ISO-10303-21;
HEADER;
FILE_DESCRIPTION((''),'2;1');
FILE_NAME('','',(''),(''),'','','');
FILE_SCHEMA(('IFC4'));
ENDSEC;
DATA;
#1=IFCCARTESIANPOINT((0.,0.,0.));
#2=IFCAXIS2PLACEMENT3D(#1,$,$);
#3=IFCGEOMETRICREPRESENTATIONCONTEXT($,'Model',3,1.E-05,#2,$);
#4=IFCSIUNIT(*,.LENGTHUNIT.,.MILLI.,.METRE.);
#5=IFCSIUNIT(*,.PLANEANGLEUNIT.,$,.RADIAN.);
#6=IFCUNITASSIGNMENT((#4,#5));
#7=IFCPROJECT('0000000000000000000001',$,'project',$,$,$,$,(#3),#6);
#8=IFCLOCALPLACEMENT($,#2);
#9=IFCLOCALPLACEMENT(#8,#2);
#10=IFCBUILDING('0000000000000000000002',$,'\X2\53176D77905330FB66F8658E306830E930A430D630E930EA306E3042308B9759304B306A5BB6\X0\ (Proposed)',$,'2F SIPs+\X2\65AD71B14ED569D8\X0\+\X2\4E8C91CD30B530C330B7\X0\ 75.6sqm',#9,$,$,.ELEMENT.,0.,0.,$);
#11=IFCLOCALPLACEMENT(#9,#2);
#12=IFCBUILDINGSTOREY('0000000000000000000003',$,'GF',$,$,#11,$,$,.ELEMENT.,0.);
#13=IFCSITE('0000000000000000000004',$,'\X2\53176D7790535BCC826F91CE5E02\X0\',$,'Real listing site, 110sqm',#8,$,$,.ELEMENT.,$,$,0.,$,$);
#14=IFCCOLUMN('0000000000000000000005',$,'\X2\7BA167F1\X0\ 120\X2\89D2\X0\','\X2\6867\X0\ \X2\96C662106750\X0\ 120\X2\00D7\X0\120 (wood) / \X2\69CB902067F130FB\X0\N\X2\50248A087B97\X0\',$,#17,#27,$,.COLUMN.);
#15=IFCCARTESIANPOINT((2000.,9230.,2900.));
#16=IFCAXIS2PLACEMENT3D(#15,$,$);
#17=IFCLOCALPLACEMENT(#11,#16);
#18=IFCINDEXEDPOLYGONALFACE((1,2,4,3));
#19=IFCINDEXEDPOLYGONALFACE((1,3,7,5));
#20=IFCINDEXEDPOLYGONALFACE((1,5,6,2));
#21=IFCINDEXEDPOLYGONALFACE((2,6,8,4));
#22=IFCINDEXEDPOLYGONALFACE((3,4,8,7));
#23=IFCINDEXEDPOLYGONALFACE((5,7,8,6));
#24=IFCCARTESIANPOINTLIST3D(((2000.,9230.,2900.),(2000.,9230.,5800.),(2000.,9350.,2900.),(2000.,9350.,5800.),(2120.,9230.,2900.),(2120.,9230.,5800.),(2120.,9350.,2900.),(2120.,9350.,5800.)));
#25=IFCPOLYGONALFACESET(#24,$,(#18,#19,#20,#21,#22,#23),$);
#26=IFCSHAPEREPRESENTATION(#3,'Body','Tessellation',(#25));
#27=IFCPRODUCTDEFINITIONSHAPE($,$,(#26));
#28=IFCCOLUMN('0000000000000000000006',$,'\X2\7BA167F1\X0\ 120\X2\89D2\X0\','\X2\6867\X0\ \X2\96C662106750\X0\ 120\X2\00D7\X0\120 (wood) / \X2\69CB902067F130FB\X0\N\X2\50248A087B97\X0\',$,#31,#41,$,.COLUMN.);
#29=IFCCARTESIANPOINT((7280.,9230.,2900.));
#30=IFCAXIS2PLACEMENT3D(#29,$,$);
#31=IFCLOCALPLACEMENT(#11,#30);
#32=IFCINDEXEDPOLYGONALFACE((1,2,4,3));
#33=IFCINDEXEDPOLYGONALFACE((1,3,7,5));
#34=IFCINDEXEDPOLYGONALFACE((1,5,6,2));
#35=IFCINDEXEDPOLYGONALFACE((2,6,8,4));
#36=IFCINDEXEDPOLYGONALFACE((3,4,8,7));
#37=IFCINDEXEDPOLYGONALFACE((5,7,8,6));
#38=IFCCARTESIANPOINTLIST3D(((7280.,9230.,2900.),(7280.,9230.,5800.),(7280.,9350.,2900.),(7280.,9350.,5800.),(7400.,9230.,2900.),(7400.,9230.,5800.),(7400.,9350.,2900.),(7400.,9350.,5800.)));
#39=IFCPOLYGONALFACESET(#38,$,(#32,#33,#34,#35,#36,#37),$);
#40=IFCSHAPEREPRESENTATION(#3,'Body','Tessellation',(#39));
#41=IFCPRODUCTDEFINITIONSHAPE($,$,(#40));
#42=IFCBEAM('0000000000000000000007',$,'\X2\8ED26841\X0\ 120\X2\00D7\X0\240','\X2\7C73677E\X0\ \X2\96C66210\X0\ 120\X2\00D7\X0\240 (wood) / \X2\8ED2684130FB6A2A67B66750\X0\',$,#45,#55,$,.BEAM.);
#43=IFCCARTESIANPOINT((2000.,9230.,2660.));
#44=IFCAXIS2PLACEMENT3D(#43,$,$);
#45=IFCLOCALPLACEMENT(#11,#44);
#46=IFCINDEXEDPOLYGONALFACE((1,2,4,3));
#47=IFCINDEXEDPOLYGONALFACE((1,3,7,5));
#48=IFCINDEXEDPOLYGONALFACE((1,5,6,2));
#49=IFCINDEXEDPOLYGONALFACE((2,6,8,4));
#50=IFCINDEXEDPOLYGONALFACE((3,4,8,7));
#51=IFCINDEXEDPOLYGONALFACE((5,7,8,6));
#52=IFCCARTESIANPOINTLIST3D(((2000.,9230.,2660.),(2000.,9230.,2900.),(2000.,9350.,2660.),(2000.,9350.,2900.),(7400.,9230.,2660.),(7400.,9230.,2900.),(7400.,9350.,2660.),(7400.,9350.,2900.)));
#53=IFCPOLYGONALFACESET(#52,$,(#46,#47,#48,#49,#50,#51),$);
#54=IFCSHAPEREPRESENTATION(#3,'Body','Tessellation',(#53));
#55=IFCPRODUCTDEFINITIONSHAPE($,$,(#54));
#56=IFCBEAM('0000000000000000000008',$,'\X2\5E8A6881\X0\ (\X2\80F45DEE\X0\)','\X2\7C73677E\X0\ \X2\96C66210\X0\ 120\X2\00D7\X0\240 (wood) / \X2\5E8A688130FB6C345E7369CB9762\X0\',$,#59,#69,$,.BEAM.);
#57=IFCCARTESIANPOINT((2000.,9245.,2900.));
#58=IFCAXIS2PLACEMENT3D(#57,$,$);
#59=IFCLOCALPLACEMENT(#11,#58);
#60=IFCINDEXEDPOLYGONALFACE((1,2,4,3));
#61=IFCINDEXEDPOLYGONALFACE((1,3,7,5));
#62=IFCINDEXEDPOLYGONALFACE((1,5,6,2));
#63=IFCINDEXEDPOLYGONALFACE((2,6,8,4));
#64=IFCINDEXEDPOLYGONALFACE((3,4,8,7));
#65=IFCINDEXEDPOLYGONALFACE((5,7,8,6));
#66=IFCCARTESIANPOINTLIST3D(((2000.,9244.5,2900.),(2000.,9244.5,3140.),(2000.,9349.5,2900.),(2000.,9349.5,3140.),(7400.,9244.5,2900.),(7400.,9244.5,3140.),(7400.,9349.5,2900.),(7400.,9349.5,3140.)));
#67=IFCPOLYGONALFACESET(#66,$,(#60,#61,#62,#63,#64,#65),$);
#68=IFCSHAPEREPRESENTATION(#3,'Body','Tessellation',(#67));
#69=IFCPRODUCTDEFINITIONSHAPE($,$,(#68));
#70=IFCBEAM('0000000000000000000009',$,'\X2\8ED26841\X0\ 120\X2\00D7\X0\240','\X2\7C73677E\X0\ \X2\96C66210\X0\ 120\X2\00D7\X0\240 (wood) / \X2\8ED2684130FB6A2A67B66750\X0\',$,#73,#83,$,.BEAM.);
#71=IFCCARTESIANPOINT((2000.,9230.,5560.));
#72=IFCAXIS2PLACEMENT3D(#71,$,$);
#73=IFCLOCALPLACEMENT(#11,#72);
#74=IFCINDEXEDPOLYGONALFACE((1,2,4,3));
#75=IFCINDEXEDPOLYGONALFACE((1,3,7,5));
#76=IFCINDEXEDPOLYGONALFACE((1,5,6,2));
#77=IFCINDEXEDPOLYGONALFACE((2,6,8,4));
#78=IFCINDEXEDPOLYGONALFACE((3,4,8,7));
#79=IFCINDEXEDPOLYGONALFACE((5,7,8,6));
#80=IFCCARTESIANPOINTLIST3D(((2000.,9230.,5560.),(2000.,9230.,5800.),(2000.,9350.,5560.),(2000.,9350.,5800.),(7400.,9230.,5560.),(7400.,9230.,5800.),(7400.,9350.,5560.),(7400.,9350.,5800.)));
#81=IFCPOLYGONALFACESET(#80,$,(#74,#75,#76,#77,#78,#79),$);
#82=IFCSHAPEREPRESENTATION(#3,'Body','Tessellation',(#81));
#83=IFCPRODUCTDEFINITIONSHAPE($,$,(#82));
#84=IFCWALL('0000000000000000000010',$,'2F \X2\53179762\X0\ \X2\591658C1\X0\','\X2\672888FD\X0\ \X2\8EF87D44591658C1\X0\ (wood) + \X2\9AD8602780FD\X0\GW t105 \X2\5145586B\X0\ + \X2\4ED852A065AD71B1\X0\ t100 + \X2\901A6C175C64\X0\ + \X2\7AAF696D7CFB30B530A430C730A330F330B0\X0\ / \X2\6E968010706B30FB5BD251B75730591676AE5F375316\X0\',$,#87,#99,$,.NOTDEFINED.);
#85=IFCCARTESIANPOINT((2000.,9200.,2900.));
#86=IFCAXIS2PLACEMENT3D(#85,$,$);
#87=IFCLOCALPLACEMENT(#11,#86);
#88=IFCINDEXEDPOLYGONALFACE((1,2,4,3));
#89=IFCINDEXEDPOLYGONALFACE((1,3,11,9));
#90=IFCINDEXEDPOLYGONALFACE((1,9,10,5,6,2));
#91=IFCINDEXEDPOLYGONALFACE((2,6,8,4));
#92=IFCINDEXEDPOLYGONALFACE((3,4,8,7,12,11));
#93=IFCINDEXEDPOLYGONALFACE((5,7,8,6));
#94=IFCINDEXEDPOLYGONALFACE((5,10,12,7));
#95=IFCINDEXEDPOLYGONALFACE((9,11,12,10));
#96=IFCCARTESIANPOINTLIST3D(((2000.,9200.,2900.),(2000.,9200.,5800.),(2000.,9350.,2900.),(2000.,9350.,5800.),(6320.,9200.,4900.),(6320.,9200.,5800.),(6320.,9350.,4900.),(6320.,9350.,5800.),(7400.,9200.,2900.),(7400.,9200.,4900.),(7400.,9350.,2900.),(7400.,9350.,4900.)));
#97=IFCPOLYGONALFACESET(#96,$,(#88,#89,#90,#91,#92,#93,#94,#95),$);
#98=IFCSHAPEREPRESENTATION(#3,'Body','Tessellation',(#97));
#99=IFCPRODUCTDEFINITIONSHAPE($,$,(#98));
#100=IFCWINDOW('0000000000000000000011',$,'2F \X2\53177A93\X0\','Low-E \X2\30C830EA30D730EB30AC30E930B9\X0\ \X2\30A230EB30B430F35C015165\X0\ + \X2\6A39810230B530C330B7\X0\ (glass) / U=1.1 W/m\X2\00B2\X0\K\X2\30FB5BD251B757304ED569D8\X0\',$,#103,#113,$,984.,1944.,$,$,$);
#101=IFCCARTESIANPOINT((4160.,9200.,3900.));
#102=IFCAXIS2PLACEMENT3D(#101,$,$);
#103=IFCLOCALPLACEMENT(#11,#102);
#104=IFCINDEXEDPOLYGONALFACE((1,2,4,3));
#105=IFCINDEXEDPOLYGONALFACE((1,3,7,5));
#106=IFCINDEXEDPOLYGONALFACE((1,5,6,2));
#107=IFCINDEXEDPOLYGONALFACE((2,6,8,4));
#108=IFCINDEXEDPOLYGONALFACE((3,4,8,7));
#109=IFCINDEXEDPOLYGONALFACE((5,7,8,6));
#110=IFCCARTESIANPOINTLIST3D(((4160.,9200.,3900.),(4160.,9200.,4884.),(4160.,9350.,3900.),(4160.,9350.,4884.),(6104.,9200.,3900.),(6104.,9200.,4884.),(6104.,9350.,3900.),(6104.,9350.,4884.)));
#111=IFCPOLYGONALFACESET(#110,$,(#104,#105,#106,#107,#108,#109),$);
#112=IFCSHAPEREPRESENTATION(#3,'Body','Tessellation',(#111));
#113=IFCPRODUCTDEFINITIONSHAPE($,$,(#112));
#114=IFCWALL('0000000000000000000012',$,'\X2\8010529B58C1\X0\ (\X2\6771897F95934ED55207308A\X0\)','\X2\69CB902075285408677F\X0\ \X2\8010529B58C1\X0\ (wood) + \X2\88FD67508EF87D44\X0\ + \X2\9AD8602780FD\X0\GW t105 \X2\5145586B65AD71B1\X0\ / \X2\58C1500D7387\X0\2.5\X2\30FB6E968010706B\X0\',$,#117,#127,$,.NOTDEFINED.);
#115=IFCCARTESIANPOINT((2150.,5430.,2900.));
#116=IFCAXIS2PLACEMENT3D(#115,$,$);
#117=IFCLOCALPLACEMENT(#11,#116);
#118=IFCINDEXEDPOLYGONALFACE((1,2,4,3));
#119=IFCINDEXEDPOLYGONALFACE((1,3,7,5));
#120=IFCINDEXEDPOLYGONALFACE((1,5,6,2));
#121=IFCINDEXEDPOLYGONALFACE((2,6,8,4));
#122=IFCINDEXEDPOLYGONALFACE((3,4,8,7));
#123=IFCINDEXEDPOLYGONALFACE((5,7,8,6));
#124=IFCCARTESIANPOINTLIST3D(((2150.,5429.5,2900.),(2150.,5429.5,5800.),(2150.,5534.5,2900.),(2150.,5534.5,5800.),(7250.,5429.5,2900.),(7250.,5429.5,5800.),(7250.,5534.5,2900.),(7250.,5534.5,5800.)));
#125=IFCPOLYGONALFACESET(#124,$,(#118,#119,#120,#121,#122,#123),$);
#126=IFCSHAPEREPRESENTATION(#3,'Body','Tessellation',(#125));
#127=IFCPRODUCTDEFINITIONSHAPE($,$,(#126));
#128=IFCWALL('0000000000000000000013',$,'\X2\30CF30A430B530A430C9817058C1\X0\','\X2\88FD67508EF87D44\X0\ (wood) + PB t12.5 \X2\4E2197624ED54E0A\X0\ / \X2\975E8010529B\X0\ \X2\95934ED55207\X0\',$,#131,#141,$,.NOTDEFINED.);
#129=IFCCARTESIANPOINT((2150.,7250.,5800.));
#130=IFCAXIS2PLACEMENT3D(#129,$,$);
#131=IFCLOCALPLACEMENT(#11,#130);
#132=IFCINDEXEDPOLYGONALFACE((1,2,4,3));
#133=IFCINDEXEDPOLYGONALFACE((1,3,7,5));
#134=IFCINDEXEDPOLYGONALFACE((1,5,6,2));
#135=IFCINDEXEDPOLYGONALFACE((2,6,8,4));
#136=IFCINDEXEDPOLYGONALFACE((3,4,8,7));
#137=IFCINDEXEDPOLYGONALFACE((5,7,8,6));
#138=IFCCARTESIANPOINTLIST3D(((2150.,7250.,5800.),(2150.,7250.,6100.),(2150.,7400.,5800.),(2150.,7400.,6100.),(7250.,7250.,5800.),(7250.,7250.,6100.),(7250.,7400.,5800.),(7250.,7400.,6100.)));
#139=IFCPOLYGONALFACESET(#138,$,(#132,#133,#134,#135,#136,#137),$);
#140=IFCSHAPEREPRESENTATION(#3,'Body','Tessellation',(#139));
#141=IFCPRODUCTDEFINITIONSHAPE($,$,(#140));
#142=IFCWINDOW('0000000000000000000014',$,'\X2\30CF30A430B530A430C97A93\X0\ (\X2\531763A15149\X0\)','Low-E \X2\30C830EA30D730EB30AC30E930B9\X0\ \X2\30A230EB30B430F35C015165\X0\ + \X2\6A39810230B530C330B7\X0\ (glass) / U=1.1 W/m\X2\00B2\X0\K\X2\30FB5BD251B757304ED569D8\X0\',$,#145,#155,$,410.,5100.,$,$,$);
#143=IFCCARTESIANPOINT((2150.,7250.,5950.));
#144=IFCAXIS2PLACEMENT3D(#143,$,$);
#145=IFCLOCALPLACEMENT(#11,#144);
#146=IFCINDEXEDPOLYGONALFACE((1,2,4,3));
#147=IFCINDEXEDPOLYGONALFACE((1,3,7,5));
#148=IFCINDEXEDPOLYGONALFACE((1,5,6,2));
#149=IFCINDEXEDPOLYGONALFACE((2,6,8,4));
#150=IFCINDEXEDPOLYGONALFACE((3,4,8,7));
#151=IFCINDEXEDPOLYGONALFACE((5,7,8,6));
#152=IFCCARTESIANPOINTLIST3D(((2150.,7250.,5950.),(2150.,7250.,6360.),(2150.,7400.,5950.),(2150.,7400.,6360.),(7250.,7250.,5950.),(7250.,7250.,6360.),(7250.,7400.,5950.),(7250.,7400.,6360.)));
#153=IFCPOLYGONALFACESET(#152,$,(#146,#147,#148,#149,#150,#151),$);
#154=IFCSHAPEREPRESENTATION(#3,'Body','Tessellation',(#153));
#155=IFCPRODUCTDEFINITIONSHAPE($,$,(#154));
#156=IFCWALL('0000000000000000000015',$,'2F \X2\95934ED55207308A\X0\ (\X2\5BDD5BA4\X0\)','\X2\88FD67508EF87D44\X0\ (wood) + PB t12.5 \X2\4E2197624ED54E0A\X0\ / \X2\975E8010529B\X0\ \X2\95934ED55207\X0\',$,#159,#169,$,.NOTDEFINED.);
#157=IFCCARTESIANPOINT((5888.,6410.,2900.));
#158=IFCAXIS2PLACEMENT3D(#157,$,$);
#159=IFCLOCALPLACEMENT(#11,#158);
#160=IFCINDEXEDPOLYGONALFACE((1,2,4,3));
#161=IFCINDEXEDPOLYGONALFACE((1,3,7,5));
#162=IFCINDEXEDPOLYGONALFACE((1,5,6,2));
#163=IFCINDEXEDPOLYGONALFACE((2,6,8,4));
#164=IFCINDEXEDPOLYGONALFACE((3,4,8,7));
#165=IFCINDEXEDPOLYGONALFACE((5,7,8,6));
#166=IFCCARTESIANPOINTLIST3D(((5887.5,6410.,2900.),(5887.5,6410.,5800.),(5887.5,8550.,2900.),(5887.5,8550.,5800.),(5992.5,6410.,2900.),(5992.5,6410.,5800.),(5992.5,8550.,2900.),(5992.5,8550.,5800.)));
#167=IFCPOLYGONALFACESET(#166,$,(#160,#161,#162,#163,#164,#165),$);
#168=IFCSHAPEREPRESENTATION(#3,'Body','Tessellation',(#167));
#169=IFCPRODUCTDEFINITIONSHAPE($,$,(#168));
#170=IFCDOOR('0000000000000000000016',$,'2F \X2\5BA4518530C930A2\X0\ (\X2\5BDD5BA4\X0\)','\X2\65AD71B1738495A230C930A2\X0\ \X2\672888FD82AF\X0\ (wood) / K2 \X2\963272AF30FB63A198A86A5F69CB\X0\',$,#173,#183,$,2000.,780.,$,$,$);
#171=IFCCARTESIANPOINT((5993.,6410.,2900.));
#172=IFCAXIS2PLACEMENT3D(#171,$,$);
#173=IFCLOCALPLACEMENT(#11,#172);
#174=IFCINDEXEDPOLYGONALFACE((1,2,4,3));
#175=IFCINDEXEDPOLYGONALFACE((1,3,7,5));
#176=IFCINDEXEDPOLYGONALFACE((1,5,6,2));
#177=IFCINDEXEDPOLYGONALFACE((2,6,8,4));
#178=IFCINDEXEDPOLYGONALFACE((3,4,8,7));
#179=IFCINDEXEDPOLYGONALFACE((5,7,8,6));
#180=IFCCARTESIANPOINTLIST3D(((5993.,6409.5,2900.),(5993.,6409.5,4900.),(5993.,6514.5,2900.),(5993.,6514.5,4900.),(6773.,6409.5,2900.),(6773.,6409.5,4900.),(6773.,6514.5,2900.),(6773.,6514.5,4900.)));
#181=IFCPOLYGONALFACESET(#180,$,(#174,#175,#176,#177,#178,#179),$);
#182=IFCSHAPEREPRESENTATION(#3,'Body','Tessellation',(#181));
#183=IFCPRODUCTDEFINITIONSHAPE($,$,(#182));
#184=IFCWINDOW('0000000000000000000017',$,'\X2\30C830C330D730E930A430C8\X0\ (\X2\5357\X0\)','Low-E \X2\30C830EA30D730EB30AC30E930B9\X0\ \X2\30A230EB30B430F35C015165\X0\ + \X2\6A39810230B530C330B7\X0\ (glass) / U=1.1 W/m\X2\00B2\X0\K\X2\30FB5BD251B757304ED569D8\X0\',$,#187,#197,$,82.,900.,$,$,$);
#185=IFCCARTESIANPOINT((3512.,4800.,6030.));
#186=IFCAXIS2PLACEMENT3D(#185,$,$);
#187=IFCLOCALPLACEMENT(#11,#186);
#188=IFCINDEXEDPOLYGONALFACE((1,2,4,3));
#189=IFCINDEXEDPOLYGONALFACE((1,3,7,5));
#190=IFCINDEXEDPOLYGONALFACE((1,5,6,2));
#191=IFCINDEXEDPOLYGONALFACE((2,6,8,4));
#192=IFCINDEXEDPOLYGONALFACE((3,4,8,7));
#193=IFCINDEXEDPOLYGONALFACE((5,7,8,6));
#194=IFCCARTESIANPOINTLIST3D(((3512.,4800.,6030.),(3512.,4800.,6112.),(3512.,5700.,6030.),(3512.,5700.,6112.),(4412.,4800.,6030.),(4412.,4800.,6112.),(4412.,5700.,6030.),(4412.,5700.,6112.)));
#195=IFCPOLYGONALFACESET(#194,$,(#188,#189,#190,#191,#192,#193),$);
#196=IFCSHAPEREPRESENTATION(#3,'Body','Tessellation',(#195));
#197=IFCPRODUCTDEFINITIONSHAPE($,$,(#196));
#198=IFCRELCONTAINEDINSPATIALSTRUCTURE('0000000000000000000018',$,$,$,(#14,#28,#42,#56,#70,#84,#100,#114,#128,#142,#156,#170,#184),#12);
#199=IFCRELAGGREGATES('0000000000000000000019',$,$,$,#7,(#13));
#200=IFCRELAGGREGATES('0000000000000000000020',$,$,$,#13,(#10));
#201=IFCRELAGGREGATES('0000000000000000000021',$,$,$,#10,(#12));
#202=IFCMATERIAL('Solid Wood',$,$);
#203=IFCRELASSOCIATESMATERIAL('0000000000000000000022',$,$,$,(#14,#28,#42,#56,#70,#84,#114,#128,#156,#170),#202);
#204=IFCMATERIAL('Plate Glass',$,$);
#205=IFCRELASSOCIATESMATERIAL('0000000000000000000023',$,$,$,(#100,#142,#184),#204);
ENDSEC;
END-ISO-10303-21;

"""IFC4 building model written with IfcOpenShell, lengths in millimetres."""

from ifc_helpers import new_model, si_unit, frame, frame_2d, origin, place, context, project, spatial, rectangle, extrude, material, element, fill, save


model = new_model("IFC4")

# Units and contexts
model_context = context("Model", 3, precision=1e-05, world=origin())
ifc_project = project(units=[si_unit("LENGTHUNIT", "METRE", prefix="MILLI"), si_unit("PLANEANGLEUNIT", "RADIAN")], contexts=[model_context])

# Site, building, storey
site_placement = place(None, origin())
site = spatial("IfcSite", under=ifc_project, at=site_placement, Name="北海道富良野市", ObjectType="Real listing site, 110sqm", CompositionType="ELEMENT", RefElevation=0.0)
building_placement = place(site_placement, origin())
building = spatial("IfcBuilding", under=site, at=building_placement, Name="北海道・書斎とライブラリのある静かな家 (Proposed)", ObjectType="2F SIPs+断熱仕様+二重サッシ 75.6sqm", CompositionType="ELEMENT", ElevationOfRefHeight=0.0, ElevationOfTerrain=0.0)
storey_placement = place(building_placement, origin())
storey = spatial("IfcBuildingStorey", under=building, at=storey_placement, Name="GF", CompositionType="ELEMENT", Elevation=0.0)

# Columns
ifc_material_1 = material(Name="Solid Wood")
column_1_placement = place(storey_placement, frame((2000.0, 9230.0, 2900.0)))
element("IfcColumn", 1, at=column_1_placement, inside=storey, material=ifc_material_1, Name="管柱 120角", Description="桧 集成材 120×120 (wood) / 構造柱・N値計算", PredefinedType="COLUMN", context=model_context, shape_type="SweptSolid", body=[
    extrude(rectangle(XDim=120.0, YDim=120.0, at=frame_2d((60.0, 60.0))), frame((2000.0, 9230.0, 2900.0)), (0.0, 0.0, 1.0), 2900.0),
])
column_2_placement = place(storey_placement, frame((7280.0, 9230.0, 2900.0)))
element("IfcColumn", 2, at=column_2_placement, inside=storey, material=ifc_material_1, Name="管柱 120角", Description="桧 集成材 120×120 (wood) / 構造柱・N値計算", PredefinedType="COLUMN", context=model_context, shape_type="SweptSolid", body=[
    extrude(rectangle(XDim=120.0, YDim=120.0, at=frame_2d((60.0, 60.0))), frame((7280.0, 9230.0, 2900.0)), (0.0, 0.0, 1.0), 2900.0),
])

# Beams
beam_1_placement = place(storey_placement, frame((2000.0, 9230.0, 2660.0)))
element("IfcBeam", 3, at=beam_1_placement, inside=storey, material=ifc_material_1, Name="軒桁 120×240", Description="米松 集成 120×240 (wood) / 軒桁・横架材", PredefinedType="BEAM", context=model_context, shape_type="SweptSolid", body=[
    extrude(rectangle(XDim=5400.0, YDim=120.0, at=frame_2d((2700.0, 60.0))), frame((2000.0, 9230.0, 2660.0)), (0.0, 0.0, 1.0), 240.0),
])
beam_2_placement = place(storey_placement, frame((2000.0, 9245.0, 2900.0)))
element("IfcBeam", 4, at=beam_2_placement, inside=storey, material=ifc_material_1, Name="床梁 (胴差)", Description="米松 集成 120×240 (wood) / 床梁・水平構面", PredefinedType="BEAM", context=model_context, shape_type="SweptSolid", body=[
    extrude(rectangle(XDim=5400.0, YDim=105.0, at=frame_2d((2700.0, 52.0))), frame((2000.0, 9245.0, 2900.0)), (0.0, 0.0, 1.0), 240.0),
])
beam_3_placement = place(storey_placement, frame((2000.0, 9230.0, 5560.0)))
element("IfcBeam", 5, at=beam_3_placement, inside=storey, material=ifc_material_1, Name="軒桁 120×240", Description="米松 集成 120×240 (wood) / 軒桁・横架材", PredefinedType="BEAM", context=model_context, shape_type="SweptSolid", body=[
    extrude(rectangle(XDim=5400.0, YDim=120.0, at=frame_2d((2700.0, 60.0))), frame((2000.0, 9230.0, 5560.0)), (0.0, 0.0, 1.0), 240.0),
])

# Wall, opening, window
wall_1_placement = place(storey_placement, frame((2000.0, 9200.0, 2900.0)))
wall_1 = element("IfcWall", 6, at=wall_1_placement, inside=storey, material=ifc_material_1, Name="2F 北面 外壁", Description="木製 軸組外壁 (wood) + 高性能GW t105 充填 + 付加断熱 t100 + 通気層 + 窯業系サイディング / 準耐火・寒冷地外皮強化", PredefinedType="NOTDEFINED", context=model_context, shape_type="SweptSolid", body=[
    extrude(rectangle(XDim=5400.0, YDim=150.0, at=frame_2d((2700.0, 75.0))), frame((2000.0, 9200.0, 2900.0)), (0.0, 0.0, 1.0), 2900.0),
])
opening_1_placement = place(storey_placement, frame((4160.0, 9200.0, 3900.0)))
opening_1 = element("IfcOpeningElement", 7, at=opening_1_placement, cuts=wall_1, PredefinedType="NOTDEFINED", context=model_context, shape_type="SweptSolid", body=[
    extrude(rectangle(XDim=1944.0, YDim=150.0, at=frame_2d((972.0, 75.0))), frame((4160.0, 9200.0, 3900.0)), (0.0, 0.0, 1.0), 984.0),
])
ifc_material_2 = material(Name="Plate Glass")
window_1_placement = place(storey_placement, frame((4160.0, 9200.0, 3900.0)))
window_1 = element("IfcWindow", 8, at=window_1_placement, inside=storey, material=ifc_material_2, Name="2F 北窓", Description="Low-E トリプルガラス アルゴン封入 + 樹脂サッシ (glass) / U=1.1 W/m²K・寒冷地仕様", OverallHeight=984.0, OverallWidth=1944.0, context=model_context, shape_type="SweptSolid", body=[
    extrude(rectangle(XDim=1944.0, YDim=150.0, at=frame_2d((972.0, 75.0))), frame((4160.0, 9200.0, 3900.0)), (0.0, 0.0, 1.0), 984.0),
])
fill(opening_1, window_1)

# Wall
wall_2_placement = place(storey_placement, frame((2150.0, 5430.0, 2900.0)))
element("IfcWall", 9, at=wall_2_placement, inside=storey, material=ifc_material_1, Name="耐力壁 (東西間仕切り)", Description="構造用合板 耐力壁 (wood) + 製材軸組 + 高性能GW t105 充填断熱 / 壁倍率2.5・準耐火", PredefinedType="NOTDEFINED", context=model_context, shape_type="SweptSolid", body=[
    extrude(rectangle(XDim=5100.0, YDim=105.0, at=frame_2d((2550.0, 52.0))), frame((2150.0, 5430.0, 2900.0)), (0.0, 0.0, 1.0), 2900.0),
])

# Wall, opening, window
wall_3_placement = place(storey_placement, frame((2150.0, 7250.0, 5800.0)))
wall_3 = element("IfcWall", 10, at=wall_3_placement, inside=storey, material=ifc_material_1, Name="ハイサイド腰壁", Description="製材軸組 (wood) + PB t12.5 両面仕上 / 非耐力 間仕切", PredefinedType="NOTDEFINED", context=model_context, shape_type="SweptSolid", body=[
    extrude(rectangle(XDim=5100.0, YDim=150.0, at=frame_2d((2550.0, 75.0))), frame((2150.0, 7250.0, 5800.0)), (0.0, 0.0, 1.0), 700.0),
])
opening_2_placement = place(storey_placement, frame((2150.0, 7250.0, 5950.0)))
opening_2 = element("IfcOpeningElement", 11, at=opening_2_placement, cuts=wall_3, PredefinedType="NOTDEFINED", context=model_context, shape_type="SweptSolid", body=[
    extrude(rectangle(XDim=5100.0, YDim=150.0, at=frame_2d((2550.0, 75.0))), frame((2150.0, 7250.0, 5950.0)), (0.0, 0.0, 1.0), 410.0),
])
window_2_placement = place(storey_placement, frame((2150.0, 7250.0, 5950.0)))
window_2 = element("IfcWindow", 12, at=window_2_placement, inside=storey, material=ifc_material_2, Name="ハイサイド窓 (北採光)", Description="Low-E トリプルガラス アルゴン封入 + 樹脂サッシ (glass) / U=1.1 W/m²K・寒冷地仕様", OverallHeight=410.0, OverallWidth=5100.0, context=model_context, shape_type="SweptSolid", body=[
    extrude(rectangle(XDim=5100.0, YDim=150.0, at=frame_2d((2550.0, 75.0))), frame((2150.0, 7250.0, 5950.0)), (0.0, 0.0, 1.0), 410.0),
])
fill(opening_2, window_2)

# Wall
wall_4_placement = place(storey_placement, frame((5888.0, 6410.0, 2900.0)))
element("IfcWall", 13, at=wall_4_placement, inside=storey, material=ifc_material_1, Name="2F 間仕切り (寝室)", Description="製材軸組 (wood) + PB t12.5 両面仕上 / 非耐力 間仕切", PredefinedType="NOTDEFINED", context=model_context, shape_type="SweptSolid", body=[
    extrude(rectangle(XDim=105.0, YDim=2140.0, at=frame_2d((52.0, 1070.0))), frame((5888.0, 6410.0, 2900.0)), (0.0, 0.0, 1.0), 2900.0),
])

# Door
door_placement = place(storey_placement, frame((5993.0, 6410.0, 2900.0)))
element("IfcDoor", 14, at=door_placement, inside=storey, material=ifc_material_1, Name="2F 室内ドア (寝室)", Description="断熱玄関ドア 木製芯 (wood) / K2 防犯・採風機構", OverallHeight=2000.0, OverallWidth=780.0, context=model_context, shape_type="SweptSolid", body=[
    extrude(rectangle(XDim=780.0, YDim=105.0, at=frame_2d((390.0, 52.0))), frame((5993.0, 6410.0, 2900.0)), (0.0, 0.0, 1.0), 2000.0),
])

# Window
window_3_placement = place(storey_placement, frame((3512.0, 4800.0, 6030.0)))
element("IfcWindow", 15, at=window_3_placement, inside=storey, material=ifc_material_2, Name="トップライト (南)", Description="Low-E トリプルガラス アルゴン封入 + 樹脂サッシ (glass) / U=1.1 W/m²K・寒冷地仕様", OverallHeight=82.0, OverallWidth=900.0, context=model_context, shape_type="SweptSolid", body=[
    extrude(rectangle(XDim=900.0, YDim=900.0, at=frame_2d((450.0, 450.0))), frame((3512.0, 4800.0, 6030.0)), (0.0, 0.0, 1.0), 82.0),
])

save(model, "model.ifc")
